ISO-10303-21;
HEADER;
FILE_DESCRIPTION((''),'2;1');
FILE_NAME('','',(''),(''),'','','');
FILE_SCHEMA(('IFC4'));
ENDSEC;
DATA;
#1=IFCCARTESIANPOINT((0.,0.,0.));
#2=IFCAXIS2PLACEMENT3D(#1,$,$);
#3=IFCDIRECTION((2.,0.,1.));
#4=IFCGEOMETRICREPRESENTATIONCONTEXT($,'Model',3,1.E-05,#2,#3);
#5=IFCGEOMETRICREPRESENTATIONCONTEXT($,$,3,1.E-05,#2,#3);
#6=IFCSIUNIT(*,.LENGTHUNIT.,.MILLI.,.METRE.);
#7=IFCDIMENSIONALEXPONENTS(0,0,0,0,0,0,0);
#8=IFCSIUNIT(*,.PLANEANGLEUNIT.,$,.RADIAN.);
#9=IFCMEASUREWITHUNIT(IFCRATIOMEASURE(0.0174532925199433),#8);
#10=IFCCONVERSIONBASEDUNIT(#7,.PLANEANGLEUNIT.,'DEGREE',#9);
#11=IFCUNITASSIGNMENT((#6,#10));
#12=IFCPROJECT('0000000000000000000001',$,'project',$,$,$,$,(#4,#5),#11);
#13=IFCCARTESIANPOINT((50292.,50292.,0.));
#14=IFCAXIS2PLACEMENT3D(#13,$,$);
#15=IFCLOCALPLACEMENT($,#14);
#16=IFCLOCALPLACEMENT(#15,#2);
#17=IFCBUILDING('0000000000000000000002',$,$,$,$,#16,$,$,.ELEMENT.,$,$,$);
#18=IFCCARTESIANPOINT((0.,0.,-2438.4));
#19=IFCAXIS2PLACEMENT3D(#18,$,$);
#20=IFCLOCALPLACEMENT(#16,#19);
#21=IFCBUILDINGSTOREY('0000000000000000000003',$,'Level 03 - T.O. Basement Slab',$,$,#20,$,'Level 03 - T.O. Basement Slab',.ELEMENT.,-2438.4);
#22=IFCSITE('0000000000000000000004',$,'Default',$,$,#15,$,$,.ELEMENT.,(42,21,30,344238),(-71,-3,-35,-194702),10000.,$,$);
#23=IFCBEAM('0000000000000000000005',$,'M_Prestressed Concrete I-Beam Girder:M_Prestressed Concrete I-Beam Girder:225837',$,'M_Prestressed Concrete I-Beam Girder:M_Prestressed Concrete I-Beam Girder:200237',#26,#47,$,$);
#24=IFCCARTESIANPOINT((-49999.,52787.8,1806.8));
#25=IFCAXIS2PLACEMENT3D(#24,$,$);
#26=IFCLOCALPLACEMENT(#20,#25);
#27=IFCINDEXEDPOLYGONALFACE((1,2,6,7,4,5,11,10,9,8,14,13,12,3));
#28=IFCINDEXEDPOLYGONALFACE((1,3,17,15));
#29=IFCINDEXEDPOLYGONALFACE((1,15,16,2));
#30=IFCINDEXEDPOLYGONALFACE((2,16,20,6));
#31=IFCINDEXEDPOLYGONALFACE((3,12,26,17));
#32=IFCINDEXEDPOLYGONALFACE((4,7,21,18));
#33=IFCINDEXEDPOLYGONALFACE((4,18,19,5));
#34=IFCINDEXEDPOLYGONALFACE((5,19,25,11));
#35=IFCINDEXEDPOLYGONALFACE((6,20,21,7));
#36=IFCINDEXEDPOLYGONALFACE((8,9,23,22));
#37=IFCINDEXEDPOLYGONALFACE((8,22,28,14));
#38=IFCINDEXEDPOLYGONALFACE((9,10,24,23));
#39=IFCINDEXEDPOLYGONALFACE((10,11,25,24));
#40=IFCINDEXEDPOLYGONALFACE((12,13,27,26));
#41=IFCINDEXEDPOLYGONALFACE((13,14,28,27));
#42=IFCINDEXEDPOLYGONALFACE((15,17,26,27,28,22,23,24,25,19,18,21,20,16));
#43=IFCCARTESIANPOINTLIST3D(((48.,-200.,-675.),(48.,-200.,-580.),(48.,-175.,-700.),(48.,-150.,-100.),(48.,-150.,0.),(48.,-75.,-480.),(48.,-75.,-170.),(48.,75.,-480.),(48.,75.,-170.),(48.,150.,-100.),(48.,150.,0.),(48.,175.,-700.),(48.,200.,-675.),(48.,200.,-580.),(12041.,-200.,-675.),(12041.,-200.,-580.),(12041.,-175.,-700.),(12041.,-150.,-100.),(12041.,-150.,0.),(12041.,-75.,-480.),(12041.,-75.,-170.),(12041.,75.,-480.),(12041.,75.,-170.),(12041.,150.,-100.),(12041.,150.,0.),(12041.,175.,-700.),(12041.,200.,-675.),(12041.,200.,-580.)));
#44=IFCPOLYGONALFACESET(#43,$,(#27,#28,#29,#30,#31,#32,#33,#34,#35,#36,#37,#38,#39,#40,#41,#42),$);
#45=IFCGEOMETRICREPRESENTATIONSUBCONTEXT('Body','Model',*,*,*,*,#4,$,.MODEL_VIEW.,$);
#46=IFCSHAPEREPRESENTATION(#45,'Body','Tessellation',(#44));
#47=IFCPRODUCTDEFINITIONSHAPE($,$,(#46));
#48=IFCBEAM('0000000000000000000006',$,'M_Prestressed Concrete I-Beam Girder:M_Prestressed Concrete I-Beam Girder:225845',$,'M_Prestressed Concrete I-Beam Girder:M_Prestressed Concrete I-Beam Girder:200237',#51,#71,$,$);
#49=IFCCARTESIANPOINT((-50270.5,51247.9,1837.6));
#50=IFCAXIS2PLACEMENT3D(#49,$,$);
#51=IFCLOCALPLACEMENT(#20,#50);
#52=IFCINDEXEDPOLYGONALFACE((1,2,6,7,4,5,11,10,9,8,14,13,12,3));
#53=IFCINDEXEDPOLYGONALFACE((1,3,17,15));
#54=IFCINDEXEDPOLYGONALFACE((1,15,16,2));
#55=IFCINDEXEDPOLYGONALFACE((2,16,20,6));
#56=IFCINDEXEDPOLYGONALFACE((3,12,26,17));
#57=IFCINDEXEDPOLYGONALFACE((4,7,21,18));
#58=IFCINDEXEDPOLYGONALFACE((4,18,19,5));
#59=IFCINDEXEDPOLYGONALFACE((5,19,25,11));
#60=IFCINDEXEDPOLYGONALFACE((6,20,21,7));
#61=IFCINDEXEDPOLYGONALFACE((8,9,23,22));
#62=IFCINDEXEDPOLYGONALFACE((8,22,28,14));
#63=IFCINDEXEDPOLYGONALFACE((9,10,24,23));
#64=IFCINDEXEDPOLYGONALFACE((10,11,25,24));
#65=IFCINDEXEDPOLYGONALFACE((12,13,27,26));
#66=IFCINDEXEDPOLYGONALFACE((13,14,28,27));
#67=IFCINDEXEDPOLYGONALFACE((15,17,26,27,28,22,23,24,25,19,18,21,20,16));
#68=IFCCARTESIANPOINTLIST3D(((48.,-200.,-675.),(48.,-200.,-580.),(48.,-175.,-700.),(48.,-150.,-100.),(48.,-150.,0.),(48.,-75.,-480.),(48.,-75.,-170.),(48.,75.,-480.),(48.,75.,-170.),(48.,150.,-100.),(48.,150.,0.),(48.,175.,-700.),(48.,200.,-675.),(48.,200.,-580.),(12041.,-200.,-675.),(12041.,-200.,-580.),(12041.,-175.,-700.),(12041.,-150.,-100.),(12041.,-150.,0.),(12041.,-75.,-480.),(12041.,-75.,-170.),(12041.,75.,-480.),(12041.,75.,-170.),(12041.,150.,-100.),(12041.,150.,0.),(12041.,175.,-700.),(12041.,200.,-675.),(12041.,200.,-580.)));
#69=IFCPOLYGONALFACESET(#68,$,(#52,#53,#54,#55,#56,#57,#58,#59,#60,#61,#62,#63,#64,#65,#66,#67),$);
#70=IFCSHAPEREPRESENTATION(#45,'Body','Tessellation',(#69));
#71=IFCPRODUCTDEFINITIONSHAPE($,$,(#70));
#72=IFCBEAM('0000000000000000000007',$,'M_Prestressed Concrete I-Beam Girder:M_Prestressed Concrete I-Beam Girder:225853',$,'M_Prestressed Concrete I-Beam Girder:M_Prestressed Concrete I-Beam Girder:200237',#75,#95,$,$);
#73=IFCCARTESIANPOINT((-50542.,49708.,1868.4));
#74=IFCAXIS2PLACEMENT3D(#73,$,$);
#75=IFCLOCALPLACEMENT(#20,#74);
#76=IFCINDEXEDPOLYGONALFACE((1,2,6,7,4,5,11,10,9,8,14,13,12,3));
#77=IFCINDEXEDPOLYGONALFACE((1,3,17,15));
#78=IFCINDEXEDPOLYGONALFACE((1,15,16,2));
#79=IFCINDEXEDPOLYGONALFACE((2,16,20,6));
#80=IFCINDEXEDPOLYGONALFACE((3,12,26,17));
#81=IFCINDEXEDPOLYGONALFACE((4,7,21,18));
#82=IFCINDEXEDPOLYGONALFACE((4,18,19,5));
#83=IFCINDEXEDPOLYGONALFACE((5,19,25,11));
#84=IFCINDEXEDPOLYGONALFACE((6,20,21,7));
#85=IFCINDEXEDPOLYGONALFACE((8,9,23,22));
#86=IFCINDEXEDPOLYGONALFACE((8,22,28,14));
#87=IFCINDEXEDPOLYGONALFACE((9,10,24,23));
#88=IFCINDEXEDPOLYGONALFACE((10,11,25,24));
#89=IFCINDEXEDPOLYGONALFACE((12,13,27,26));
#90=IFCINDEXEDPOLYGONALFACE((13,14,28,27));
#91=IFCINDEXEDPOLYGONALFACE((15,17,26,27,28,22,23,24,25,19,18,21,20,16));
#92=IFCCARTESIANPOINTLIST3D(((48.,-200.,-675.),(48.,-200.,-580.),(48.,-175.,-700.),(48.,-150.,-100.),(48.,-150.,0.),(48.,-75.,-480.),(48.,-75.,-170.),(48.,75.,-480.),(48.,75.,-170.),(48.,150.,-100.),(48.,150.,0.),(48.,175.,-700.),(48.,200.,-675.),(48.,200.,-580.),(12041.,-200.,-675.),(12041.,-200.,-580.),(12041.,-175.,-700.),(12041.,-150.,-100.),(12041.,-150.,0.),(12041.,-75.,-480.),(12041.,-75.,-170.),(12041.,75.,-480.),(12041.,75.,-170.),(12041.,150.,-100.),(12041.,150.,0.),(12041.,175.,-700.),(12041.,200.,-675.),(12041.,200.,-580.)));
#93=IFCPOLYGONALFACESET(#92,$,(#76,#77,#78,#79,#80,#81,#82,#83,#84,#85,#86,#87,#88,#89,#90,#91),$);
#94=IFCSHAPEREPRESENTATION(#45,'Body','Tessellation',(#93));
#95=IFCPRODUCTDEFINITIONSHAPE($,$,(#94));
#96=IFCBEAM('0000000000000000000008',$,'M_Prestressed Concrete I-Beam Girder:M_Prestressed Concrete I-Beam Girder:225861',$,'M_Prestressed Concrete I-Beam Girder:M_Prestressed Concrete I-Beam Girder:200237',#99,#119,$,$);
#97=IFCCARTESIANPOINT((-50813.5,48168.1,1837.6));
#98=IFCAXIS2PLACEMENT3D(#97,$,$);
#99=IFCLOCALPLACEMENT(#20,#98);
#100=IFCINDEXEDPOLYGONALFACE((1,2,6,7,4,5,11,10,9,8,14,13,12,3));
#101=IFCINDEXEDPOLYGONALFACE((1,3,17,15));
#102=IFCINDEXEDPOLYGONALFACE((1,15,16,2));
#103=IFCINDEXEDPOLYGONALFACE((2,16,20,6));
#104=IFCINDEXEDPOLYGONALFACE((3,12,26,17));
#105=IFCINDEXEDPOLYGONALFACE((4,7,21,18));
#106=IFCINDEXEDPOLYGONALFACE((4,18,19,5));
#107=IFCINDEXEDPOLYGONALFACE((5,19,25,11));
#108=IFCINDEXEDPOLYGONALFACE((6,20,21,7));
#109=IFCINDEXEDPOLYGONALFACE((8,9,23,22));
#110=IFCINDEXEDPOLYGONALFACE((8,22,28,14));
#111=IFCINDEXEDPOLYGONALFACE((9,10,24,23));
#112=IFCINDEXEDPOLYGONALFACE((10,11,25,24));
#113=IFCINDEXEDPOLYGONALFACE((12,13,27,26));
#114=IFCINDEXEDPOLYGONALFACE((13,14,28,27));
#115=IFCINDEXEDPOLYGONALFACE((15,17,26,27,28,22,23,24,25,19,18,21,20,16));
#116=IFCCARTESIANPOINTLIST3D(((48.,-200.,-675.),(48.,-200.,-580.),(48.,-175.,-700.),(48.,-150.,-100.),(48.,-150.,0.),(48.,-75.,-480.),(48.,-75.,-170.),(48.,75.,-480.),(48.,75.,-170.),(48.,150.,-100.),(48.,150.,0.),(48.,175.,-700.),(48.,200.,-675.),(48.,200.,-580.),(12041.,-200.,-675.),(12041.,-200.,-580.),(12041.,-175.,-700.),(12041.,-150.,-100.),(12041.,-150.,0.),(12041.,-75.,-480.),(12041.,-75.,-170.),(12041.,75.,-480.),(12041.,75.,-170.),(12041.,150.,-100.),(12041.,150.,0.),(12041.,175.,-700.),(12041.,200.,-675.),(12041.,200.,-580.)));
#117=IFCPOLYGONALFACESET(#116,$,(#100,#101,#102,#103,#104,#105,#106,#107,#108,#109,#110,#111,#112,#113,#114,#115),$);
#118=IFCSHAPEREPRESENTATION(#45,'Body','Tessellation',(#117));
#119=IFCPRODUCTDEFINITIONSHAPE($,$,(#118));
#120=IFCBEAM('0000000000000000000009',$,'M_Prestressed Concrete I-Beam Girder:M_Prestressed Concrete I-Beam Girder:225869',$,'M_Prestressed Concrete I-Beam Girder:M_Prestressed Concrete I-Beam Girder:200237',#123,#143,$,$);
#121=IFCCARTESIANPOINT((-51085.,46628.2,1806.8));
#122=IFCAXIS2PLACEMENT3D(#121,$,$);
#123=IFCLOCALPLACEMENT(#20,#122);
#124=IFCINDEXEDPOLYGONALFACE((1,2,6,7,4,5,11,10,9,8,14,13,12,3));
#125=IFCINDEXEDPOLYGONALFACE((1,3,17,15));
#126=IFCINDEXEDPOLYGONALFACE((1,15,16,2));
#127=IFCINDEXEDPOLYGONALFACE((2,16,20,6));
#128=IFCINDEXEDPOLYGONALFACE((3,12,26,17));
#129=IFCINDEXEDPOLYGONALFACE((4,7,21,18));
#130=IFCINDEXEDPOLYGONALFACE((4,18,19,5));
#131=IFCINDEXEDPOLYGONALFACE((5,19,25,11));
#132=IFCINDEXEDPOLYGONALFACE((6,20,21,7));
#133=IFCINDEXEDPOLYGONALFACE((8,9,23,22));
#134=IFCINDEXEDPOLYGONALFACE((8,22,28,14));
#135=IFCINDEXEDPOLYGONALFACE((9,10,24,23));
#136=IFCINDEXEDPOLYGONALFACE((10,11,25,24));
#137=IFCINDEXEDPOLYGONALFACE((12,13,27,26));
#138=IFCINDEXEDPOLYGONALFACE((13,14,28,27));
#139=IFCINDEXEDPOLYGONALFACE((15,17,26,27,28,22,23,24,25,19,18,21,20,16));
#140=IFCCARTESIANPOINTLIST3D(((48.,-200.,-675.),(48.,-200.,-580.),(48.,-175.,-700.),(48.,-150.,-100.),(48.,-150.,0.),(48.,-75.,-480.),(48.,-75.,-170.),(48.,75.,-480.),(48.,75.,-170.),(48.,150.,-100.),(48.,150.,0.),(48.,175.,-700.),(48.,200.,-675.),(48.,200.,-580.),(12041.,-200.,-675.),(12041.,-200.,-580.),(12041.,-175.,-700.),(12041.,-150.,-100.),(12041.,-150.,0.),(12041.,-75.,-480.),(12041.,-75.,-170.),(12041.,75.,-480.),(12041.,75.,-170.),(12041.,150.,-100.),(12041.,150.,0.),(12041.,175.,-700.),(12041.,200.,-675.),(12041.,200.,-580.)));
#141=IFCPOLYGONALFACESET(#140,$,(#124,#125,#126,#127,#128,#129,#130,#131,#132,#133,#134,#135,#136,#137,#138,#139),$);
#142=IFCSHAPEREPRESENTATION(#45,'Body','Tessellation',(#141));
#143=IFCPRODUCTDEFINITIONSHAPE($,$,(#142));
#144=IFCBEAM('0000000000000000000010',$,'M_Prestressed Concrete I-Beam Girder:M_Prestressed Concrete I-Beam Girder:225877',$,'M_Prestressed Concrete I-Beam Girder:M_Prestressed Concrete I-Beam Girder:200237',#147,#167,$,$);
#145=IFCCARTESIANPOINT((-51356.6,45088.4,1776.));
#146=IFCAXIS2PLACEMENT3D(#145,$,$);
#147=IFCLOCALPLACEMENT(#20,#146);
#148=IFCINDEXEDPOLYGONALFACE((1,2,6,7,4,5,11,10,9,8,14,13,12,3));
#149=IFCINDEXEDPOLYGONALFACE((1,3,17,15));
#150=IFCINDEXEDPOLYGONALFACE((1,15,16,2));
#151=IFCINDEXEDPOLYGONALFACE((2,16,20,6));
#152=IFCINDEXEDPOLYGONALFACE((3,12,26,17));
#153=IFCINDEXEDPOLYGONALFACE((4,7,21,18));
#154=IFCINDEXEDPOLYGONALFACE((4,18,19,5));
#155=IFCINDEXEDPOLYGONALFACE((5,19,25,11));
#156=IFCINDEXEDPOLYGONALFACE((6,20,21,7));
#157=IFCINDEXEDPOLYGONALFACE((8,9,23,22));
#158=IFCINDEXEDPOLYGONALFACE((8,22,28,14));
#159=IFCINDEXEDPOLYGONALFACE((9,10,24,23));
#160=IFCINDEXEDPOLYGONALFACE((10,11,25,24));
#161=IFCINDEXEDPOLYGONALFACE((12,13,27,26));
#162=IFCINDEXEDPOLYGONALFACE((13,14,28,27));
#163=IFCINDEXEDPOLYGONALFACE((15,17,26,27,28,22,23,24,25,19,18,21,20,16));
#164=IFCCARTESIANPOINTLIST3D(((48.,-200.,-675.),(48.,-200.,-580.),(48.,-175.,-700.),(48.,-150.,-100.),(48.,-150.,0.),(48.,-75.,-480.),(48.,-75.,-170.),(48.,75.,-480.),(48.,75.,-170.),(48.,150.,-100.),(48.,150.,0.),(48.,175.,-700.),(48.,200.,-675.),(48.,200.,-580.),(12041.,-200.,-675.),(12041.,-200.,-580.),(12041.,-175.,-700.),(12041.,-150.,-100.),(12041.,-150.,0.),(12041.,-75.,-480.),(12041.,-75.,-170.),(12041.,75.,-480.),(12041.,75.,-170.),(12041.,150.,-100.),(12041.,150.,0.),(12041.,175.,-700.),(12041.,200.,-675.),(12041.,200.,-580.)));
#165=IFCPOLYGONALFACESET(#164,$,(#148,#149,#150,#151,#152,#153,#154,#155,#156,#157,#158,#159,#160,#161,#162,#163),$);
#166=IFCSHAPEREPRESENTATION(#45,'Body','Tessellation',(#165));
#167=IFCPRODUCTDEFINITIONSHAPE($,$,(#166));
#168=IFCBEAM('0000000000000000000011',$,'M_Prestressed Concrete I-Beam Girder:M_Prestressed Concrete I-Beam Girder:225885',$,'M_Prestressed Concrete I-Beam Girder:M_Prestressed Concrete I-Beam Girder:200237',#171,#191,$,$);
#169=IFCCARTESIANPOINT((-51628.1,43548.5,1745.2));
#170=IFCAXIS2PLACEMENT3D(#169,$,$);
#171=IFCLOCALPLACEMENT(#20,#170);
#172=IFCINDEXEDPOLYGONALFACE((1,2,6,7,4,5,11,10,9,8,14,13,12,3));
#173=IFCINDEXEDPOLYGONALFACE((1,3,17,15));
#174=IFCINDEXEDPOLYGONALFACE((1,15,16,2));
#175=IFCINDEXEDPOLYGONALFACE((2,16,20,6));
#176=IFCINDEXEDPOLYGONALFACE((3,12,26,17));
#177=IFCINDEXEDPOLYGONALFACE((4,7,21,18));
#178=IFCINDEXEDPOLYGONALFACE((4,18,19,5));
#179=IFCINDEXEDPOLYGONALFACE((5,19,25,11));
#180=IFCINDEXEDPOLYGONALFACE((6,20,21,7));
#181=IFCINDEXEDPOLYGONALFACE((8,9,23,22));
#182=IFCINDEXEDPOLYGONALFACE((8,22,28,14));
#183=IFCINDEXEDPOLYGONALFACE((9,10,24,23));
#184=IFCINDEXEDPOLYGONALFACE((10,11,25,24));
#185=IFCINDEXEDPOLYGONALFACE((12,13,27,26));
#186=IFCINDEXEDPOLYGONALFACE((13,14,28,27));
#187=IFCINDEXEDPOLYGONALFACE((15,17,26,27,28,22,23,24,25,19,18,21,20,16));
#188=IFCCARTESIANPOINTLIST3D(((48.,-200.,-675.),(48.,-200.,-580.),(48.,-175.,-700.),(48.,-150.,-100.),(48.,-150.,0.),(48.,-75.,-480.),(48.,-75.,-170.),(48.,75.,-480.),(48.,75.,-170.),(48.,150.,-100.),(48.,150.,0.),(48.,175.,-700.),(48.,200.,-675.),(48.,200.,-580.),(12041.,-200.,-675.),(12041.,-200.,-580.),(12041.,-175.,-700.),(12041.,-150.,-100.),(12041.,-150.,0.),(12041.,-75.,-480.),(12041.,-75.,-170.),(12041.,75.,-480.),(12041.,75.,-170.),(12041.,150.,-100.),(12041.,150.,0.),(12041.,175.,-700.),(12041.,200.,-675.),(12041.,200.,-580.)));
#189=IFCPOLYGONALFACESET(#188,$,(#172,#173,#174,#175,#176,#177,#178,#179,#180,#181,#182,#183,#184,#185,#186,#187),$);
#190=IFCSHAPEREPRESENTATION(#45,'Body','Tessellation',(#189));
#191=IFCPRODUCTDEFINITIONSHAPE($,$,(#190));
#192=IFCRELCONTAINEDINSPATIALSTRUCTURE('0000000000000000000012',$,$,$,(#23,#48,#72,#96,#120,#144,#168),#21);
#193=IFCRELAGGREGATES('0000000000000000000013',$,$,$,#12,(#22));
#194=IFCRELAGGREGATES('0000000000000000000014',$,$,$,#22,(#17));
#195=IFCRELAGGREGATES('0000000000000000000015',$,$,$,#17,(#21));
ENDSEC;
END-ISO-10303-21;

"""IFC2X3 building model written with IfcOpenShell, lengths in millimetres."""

from ifc_helpers import new_model, entity, si_unit, converted_unit, direction, frame, origin, place, context, subcontext, project, spatial, polyline, outline, extrude, element, save


model = new_model("IFC2X3")

# Units and contexts
model_context = context("Model", 3, precision=1e-05, world=origin(), true_north=direction((2.0, 0.0, 1.0)))
context_of_model = context(None, 3, precision=1e-05, world=origin(), true_north=direction((2.0, 0.0, 1.0)))
body_context = subcontext(model_context, "Body", "Model", "MODEL_VIEW")
ifc_project = project(units=[si_unit("LENGTHUNIT", "METRE", prefix="MILLI"), converted_unit("PLANEANGLEUNIT", "DEGREE", entity("IfcRatioMeasure", 0.0174532925199433), si_unit("PLANEANGLEUNIT", "RADIAN"), dimensions=[0, 0, 0, 0, 0, 0, 0])], contexts=[model_context, context_of_model])

# Site, building, storey
site_placement = place(None, frame((50292.0, 50292.0, 0.0)))
site = spatial("IfcSite", under=ifc_project, at=site_placement, Name="Default", CompositionType="ELEMENT", RefLatitude=(42, 21, 30, 344238), RefLongitude=(-71, -3, -35, -194702), RefElevation=10000.0)
building_placement = place(site_placement, origin())
building = spatial("IfcBuilding", under=site, at=building_placement, CompositionType="ELEMENT")
storey_placement = place(building_placement, frame((0.0, 0.0, -2438.4)))
storey = spatial("IfcBuildingStorey", under=building, at=storey_placement, Name="Level 03 - T.O. Basement Slab", LongName="Level 03 - T.O. Basement Slab", CompositionType="ELEMENT", Elevation=-2438.4)

# Beams
beam_1_placement = place(storey_placement, frame((-49999.0, 52787.8, 1806.8)))
element("IfcBeam", 1, at=beam_1_placement, inside=storey, Name="M_Prestressed Concrete I-Beam Girder:M_Prestressed Concrete I-Beam Girder:225837", ObjectType="M_Prestressed Concrete I-Beam Girder:M_Prestressed Concrete I-Beam Girder:200237", context=body_context, shape_type="SweptSolid", body=[
    extrude(outline(polyline([(193.6, -200.0), (288.6, -200.0), (313.6, -175.0), (313.6, 175.0), (288.6, 200.0), (193.6, 200.0), (93.6, 75.0), (-216.4, 75.0), (-286.4, 150.0), (-386.4, 150.0), (-386.4, -150.0), (-286.4, -150.0), (-216.4, -75.0), (93.6, -75.0), (193.6, -200.0)])), frame((48.0, 0.0, -386.4), z_axis=(1.0, 0.0, 0.0), x_axis=(0.0, 0.0, -1.0)), (0.0, 0.0, 1.0), 11993.0),
])
beam_2_placement = place(storey_placement, frame((-50270.5, 51247.9, 1837.6)))
element("IfcBeam", 2, at=beam_2_placement, inside=storey, Name="M_Prestressed Concrete I-Beam Girder:M_Prestressed Concrete I-Beam Girder:225845", ObjectType="M_Prestressed Concrete I-Beam Girder:M_Prestressed Concrete I-Beam Girder:200237", context=body_context, shape_type="SweptSolid", body=[
    extrude(outline(polyline([(193.6, -200.0), (288.6, -200.0), (313.6, -175.0), (313.6, 175.0), (288.6, 200.0), (193.6, 200.0), (93.6, 75.0), (-216.4, 75.0), (-286.4, 150.0), (-386.4, 150.0), (-386.4, -150.0), (-286.4, -150.0), (-216.4, -75.0), (93.6, -75.0), (193.6, -200.0)])), frame((48.0, 0.0, -386.4), z_axis=(1.0, 0.0, 0.0), x_axis=(0.0, 0.0, -1.0)), (0.0, 0.0, 1.0), 11993.0),
])
beam_3_placement = place(storey_placement, frame((-50542.0, 49708.0, 1868.4)))
element("IfcBeam", 3, at=beam_3_placement, inside=storey, Name="M_Prestressed Concrete I-Beam Girder:M_Prestressed Concrete I-Beam Girder:225853", ObjectType="M_Prestressed Concrete I-Beam Girder:M_Prestressed Concrete I-Beam Girder:200237", context=body_context, shape_type="SweptSolid", body=[
    extrude(outline(polyline([(193.6, -200.0), (288.6, -200.0), (313.6, -175.0), (313.6, 175.0), (288.6, 200.0), (193.6, 200.0), (93.6, 75.0), (-216.4, 75.0), (-286.4, 150.0), (-386.4, 150.0), (-386.4, -150.0), (-286.4, -150.0), (-216.4, -75.0), (93.6, -75.0), (193.6, -200.0)])), frame((48.0, 0.0, -386.4), z_axis=(1.0, 0.0, 0.0), x_axis=(0.0, 0.0, -1.0)), (0.0, 0.0, 1.0), 11993.0),
])
beam_4_placement = place(storey_placement, frame((-50813.5, 48168.1, 1837.6)))
element("IfcBeam", 4, at=beam_4_placement, inside=storey, Name="M_Prestressed Concrete I-Beam Girder:M_Prestressed Concrete I-Beam Girder:225861", ObjectType="M_Prestressed Concrete I-Beam Girder:M_Prestressed Concrete I-Beam Girder:200237", context=body_context, shape_type="SweptSolid", body=[
    extrude(outline(polyline([(193.6, -200.0), (288.6, -200.0), (313.6, -175.0), (313.6, 175.0), (288.6, 200.0), (193.6, 200.0), (93.6, 75.0), (-216.4, 75.0), (-286.4, 150.0), (-386.4, 150.0), (-386.4, -150.0), (-286.4, -150.0), (-216.4, -75.0), (93.6, -75.0), (193.6, -200.0)])), frame((48.0, 0.0, -386.4), z_axis=(1.0, 0.0, 0.0), x_axis=(0.0, 0.0, -1.0)), (0.0, 0.0, 1.0), 11993.0),
])
beam_5_placement = place(storey_placement, frame((-51085.0, 46628.2, 1806.8)))
element("IfcBeam", 5, at=beam_5_placement, inside=storey, Name="M_Prestressed Concrete I-Beam Girder:M_Prestressed Concrete I-Beam Girder:225869", ObjectType="M_Prestressed Concrete I-Beam Girder:M_Prestressed Concrete I-Beam Girder:200237", context=body_context, shape_type="SweptSolid", body=[
    extrude(outline(polyline([(193.6, -200.0), (288.6, -200.0), (313.6, -175.0), (313.6, 175.0), (288.6, 200.0), (193.6, 200.0), (93.6, 75.0), (-216.4, 75.0), (-286.4, 150.0), (-386.4, 150.0), (-386.4, -150.0), (-286.4, -150.0), (-216.4, -75.0), (93.6, -75.0), (193.6, -200.0)])), frame((48.0, 0.0, -386.4), z_axis=(1.0, 0.0, 0.0), x_axis=(0.0, 0.0, -1.0)), (0.0, 0.0, 1.0), 11993.0),
])
beam_6_placement = place(storey_placement, frame((-51356.6, 45088.4, 1776.0)))
element("IfcBeam", 6, at=beam_6_placement, inside=storey, Name="M_Prestressed Concrete I-Beam Girder:M_Prestressed Concrete I-Beam Girder:225877", ObjectType="M_Prestressed Concrete I-Beam Girder:M_Prestressed Concrete I-Beam Girder:200237", context=body_context, shape_type="SweptSolid", body=[
    extrude(outline(polyline([(193.6, -200.0), (288.6, -200.0), (313.6, -175.0), (313.6, 175.0), (288.6, 200.0), (193.6, 200.0), (93.6, 75.0), (-216.4, 75.0), (-286.4, 150.0), (-386.4, 150.0), (-386.4, -150.0), (-286.4, -150.0), (-216.4, -75.0), (93.6, -75.0), (193.6, -200.0)])), frame((48.0, 0.0, -386.4), z_axis=(1.0, 0.0, 0.0), x_axis=(0.0, 0.0, -1.0)), (0.0, 0.0, 1.0), 11993.0),
])
beam_7_placement = place(storey_placement, frame((-51628.1, 43548.5, 1745.2)))
element("IfcBeam", 7, at=beam_7_placement, inside=storey, Name="M_Prestressed Concrete I-Beam Girder:M_Prestressed Concrete I-Beam Girder:225885", ObjectType="M_Prestressed Concrete I-Beam Girder:M_Prestressed Concrete I-Beam Girder:200237", context=body_context, shape_type="SweptSolid", body=[
    extrude(outline(polyline([(193.6, -200.0), (288.6, -200.0), (313.6, -175.0), (313.6, 175.0), (288.6, 200.0), (193.6, 200.0), (93.6, 75.0), (-216.4, 75.0), (-286.4, 150.0), (-386.4, 150.0), (-386.4, -150.0), (-286.4, -150.0), (-216.4, -75.0), (93.6, -75.0), (193.6, -200.0)])), frame((48.0, 0.0, -386.4), z_axis=(1.0, 0.0, 0.0), x_axis=(0.0, 0.0, -1.0)), (0.0, 0.0, 1.0), 11993.0),
])

save(model, "model.ifc")
